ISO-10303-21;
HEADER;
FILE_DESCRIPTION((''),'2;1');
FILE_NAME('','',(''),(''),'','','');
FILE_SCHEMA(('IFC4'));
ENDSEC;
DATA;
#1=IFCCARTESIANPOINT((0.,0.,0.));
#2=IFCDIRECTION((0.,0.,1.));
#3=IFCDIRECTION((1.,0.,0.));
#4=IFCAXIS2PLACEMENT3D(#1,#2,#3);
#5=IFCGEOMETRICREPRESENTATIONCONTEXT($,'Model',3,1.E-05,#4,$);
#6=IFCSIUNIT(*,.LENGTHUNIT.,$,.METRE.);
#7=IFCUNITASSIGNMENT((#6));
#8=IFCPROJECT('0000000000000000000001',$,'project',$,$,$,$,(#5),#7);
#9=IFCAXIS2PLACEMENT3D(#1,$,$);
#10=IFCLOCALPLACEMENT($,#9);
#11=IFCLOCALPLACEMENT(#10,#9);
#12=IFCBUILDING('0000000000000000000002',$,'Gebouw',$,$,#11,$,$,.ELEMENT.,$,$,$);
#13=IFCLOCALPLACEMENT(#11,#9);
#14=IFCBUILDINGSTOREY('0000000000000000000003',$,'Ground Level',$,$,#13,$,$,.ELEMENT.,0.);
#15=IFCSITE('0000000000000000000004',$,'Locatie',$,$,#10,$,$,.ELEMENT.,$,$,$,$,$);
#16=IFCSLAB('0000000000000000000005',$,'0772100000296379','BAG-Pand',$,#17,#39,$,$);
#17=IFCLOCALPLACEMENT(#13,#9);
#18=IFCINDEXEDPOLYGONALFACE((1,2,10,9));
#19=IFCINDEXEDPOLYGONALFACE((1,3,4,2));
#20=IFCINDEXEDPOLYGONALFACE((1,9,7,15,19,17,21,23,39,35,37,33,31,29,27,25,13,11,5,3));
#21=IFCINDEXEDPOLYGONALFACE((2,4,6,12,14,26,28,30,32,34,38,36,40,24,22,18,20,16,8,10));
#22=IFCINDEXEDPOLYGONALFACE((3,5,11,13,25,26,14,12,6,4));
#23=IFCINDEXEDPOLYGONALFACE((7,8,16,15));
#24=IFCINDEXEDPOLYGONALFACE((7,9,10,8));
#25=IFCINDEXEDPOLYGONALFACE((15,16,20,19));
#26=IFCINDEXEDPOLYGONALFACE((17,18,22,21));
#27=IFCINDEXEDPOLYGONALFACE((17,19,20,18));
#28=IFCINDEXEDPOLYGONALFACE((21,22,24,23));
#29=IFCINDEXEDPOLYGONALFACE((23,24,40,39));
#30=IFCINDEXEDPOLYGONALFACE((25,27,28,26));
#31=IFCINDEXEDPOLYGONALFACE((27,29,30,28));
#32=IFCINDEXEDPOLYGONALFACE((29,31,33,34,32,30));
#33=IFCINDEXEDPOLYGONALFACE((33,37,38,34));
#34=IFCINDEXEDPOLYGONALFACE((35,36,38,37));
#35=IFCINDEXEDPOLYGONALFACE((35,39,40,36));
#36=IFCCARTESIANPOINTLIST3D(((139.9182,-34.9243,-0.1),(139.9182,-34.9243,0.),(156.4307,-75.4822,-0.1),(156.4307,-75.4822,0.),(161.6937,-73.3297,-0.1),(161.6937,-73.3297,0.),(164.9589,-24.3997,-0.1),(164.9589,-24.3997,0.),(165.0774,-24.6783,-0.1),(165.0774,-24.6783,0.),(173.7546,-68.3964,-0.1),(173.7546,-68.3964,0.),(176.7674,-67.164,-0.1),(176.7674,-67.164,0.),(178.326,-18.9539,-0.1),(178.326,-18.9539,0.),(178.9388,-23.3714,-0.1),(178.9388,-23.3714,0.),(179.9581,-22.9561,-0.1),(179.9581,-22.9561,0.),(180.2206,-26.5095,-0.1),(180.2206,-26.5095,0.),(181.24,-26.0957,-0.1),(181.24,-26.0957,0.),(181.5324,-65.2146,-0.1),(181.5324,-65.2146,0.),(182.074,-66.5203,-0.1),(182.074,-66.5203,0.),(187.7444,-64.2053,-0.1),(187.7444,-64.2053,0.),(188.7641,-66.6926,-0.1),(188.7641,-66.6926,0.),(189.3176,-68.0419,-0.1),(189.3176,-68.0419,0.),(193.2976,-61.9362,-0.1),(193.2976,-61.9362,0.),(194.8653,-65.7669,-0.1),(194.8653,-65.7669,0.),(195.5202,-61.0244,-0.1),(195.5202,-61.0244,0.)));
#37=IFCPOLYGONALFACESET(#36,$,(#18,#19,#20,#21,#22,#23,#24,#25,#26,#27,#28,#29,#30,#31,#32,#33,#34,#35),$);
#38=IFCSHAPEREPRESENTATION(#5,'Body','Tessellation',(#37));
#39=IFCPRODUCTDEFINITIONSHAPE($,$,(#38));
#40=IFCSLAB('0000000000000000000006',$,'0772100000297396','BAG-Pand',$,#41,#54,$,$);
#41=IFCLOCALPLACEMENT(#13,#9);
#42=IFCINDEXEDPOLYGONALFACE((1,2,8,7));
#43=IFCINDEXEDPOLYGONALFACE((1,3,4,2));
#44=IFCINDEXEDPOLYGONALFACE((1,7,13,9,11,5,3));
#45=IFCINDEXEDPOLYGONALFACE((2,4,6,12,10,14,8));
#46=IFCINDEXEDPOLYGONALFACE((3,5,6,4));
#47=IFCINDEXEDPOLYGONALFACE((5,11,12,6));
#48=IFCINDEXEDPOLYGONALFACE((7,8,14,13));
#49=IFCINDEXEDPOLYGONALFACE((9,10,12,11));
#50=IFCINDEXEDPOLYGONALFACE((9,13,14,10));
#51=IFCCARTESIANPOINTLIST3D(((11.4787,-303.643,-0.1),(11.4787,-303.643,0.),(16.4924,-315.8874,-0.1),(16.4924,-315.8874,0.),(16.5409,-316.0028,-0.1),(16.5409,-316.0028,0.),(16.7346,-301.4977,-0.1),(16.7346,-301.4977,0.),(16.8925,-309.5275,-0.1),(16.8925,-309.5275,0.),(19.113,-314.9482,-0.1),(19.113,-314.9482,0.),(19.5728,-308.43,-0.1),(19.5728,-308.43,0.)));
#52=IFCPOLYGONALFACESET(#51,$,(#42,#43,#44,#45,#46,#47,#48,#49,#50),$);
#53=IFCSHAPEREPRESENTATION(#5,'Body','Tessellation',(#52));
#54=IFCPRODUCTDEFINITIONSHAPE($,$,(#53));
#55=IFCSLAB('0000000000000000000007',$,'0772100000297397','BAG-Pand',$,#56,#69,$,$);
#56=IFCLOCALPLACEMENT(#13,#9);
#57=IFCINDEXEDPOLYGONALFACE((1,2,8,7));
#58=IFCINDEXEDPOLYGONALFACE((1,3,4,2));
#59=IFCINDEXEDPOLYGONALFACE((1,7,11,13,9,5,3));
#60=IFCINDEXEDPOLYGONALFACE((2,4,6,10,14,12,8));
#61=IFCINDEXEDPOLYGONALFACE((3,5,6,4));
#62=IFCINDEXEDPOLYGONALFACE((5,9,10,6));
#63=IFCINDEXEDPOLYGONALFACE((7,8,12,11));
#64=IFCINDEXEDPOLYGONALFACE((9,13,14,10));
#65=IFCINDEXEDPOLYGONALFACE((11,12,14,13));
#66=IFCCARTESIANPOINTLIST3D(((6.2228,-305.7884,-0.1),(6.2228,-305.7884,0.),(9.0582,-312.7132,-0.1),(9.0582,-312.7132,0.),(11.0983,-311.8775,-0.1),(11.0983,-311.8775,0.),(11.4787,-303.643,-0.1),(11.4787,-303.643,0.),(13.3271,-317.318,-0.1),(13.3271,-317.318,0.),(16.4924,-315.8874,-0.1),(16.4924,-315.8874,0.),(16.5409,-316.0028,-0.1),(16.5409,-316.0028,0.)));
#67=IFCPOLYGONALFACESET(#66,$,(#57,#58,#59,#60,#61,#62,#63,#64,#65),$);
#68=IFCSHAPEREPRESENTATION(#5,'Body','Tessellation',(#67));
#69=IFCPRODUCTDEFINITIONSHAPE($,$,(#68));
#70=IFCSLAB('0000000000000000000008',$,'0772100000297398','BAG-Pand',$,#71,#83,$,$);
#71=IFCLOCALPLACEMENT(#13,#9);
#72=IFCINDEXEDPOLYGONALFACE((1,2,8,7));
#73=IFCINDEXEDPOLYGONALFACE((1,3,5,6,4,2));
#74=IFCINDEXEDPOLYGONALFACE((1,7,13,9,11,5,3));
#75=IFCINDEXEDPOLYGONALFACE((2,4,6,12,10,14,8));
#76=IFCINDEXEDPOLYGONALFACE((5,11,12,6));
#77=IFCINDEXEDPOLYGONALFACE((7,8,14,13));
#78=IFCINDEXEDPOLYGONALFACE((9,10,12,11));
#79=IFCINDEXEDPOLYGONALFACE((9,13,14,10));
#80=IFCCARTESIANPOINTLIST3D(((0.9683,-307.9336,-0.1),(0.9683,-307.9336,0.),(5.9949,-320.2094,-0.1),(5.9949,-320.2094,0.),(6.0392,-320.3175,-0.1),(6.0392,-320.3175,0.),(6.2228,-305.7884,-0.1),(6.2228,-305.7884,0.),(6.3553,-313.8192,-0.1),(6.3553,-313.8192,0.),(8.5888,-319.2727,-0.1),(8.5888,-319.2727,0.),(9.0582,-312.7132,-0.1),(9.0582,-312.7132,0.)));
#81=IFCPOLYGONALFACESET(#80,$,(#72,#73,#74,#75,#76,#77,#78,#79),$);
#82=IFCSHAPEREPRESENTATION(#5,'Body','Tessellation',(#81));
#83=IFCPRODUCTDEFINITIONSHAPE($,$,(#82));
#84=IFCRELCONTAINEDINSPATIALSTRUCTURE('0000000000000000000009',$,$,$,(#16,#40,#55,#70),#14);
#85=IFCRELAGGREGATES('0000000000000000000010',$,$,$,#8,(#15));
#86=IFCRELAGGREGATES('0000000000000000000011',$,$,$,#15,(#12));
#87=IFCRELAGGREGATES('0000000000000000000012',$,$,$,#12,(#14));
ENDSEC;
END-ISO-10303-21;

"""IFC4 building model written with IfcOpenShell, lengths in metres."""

from ifc_helpers import new_model, si_unit, frame, origin, origin_with_axes, place, context, project, spatial, polyline, outline, extrude, element, save


model = new_model("IFC4")

# Units and contexts
model_context = context("Model", 3, precision=1e-05, world=origin_with_axes())
ifc_project = project(units=[si_unit("LENGTHUNIT", "METRE")], contexts=[model_context])

# Site, building, storey
site_placement = place(None, origin())
site = spatial("IfcSite", under=ifc_project, at=site_placement, Name="Locatie", CompositionType="ELEMENT")
building_placement = place(site_placement, origin())
building = spatial("IfcBuilding", under=site, at=building_placement, Name="Gebouw", CompositionType="ELEMENT")
storey_placement = place(building_placement, origin())
storey = spatial("IfcBuildingStorey", under=building, at=storey_placement, Name="Ground Level", CompositionType="ELEMENT", Elevation=0.0)

# Slabs
slab_1_placement = place(storey_placement, origin())
element("IfcSlab", 1, at=slab_1_placement, inside=storey, Name="0772100000296379", Description="BAG-Pand", context=model_context, shape_type="SweptSolid", body=[
    extrude(outline(polyline([(156.4307, -75.4822), (139.9182, -34.9243), (165.0774, -24.6783), (164.9589, -24.3997), (178.326, -18.9539), (179.9581, -22.9561), (178.9388, -23.3714), (180.2206, -26.5095), (181.24, -26.0957), (195.5202, -61.0244), (193.2976, -61.9362), (194.8653, -65.7669), (189.3176, -68.0419), (188.7641, -66.6926), (187.7444, -64.2053), (182.074, -66.5203), (181.5324, -65.2146), (176.7674, -67.164), (173.7546, -68.3964), (161.6937, -73.3297), (156.4307, -75.4822)])), frame((0.0, 0.0, -0.1), z_axis=(0.0, 0.0, 1.0), x_axis=(1.0, 0.0, 0.0)), (0.0, 0.0, 1.0), 0.1),
])
slab_2_placement = place(storey_placement, origin())
element("IfcSlab", 2, at=slab_2_placement, inside=storey, Name="0772100000297396", Description="BAG-Pand", context=model_context, shape_type="SweptSolid", body=[
    extrude(outline(polyline([(16.7346, -301.4977), (19.5728, -308.43), (16.8925, -309.5275), (19.113, -314.9482), (16.5409, -316.0028), (16.4924, -315.8874), (11.4787, -303.643), (16.7346, -301.4977)])), frame((0.0, 0.0, -0.1), z_axis=(0.0, 0.0, 1.0), x_axis=(1.0, 0.0, 0.0)), (0.0, 0.0, 1.0), 0.1),
])
slab_3_placement = place(storey_placement, origin())
element("IfcSlab", 3, at=slab_3_placement, inside=storey, Name="0772100000297397", Description="BAG-Pand", context=model_context, shape_type="SweptSolid", body=[
    extrude(outline(polyline([(11.4787, -303.643), (16.4924, -315.8874), (16.5409, -316.0028), (13.3271, -317.318), (11.0983, -311.8775), (9.0582, -312.7132), (6.2228, -305.7884), (11.4787, -303.643)])), frame((0.0, 0.0, -0.1), z_axis=(0.0, 0.0, 1.0), x_axis=(1.0, 0.0, 0.0)), (0.0, 0.0, 1.0), 0.1),
])
slab_4_placement = place(storey_placement, origin())
element("IfcSlab", 4, at=slab_4_placement, inside=storey, Name="0772100000297398", Description="BAG-Pand", context=model_context, shape_type="SweptSolid", body=[
    extrude(outline(polyline([(5.9949, -320.2094), (0.9683, -307.9336), (6.2228, -305.7884), (9.0582, -312.7132), (6.3553, -313.8192), (8.5888, -319.2727), (6.0392, -320.3175), (5.9949, -320.2094)])), frame((0.0, 0.0, -0.1), z_axis=(0.0, 0.0, 1.0), x_axis=(1.0, 0.0, 0.0)), (0.0, 0.0, 1.0), 0.1),
])

save(model, "model.ifc")
